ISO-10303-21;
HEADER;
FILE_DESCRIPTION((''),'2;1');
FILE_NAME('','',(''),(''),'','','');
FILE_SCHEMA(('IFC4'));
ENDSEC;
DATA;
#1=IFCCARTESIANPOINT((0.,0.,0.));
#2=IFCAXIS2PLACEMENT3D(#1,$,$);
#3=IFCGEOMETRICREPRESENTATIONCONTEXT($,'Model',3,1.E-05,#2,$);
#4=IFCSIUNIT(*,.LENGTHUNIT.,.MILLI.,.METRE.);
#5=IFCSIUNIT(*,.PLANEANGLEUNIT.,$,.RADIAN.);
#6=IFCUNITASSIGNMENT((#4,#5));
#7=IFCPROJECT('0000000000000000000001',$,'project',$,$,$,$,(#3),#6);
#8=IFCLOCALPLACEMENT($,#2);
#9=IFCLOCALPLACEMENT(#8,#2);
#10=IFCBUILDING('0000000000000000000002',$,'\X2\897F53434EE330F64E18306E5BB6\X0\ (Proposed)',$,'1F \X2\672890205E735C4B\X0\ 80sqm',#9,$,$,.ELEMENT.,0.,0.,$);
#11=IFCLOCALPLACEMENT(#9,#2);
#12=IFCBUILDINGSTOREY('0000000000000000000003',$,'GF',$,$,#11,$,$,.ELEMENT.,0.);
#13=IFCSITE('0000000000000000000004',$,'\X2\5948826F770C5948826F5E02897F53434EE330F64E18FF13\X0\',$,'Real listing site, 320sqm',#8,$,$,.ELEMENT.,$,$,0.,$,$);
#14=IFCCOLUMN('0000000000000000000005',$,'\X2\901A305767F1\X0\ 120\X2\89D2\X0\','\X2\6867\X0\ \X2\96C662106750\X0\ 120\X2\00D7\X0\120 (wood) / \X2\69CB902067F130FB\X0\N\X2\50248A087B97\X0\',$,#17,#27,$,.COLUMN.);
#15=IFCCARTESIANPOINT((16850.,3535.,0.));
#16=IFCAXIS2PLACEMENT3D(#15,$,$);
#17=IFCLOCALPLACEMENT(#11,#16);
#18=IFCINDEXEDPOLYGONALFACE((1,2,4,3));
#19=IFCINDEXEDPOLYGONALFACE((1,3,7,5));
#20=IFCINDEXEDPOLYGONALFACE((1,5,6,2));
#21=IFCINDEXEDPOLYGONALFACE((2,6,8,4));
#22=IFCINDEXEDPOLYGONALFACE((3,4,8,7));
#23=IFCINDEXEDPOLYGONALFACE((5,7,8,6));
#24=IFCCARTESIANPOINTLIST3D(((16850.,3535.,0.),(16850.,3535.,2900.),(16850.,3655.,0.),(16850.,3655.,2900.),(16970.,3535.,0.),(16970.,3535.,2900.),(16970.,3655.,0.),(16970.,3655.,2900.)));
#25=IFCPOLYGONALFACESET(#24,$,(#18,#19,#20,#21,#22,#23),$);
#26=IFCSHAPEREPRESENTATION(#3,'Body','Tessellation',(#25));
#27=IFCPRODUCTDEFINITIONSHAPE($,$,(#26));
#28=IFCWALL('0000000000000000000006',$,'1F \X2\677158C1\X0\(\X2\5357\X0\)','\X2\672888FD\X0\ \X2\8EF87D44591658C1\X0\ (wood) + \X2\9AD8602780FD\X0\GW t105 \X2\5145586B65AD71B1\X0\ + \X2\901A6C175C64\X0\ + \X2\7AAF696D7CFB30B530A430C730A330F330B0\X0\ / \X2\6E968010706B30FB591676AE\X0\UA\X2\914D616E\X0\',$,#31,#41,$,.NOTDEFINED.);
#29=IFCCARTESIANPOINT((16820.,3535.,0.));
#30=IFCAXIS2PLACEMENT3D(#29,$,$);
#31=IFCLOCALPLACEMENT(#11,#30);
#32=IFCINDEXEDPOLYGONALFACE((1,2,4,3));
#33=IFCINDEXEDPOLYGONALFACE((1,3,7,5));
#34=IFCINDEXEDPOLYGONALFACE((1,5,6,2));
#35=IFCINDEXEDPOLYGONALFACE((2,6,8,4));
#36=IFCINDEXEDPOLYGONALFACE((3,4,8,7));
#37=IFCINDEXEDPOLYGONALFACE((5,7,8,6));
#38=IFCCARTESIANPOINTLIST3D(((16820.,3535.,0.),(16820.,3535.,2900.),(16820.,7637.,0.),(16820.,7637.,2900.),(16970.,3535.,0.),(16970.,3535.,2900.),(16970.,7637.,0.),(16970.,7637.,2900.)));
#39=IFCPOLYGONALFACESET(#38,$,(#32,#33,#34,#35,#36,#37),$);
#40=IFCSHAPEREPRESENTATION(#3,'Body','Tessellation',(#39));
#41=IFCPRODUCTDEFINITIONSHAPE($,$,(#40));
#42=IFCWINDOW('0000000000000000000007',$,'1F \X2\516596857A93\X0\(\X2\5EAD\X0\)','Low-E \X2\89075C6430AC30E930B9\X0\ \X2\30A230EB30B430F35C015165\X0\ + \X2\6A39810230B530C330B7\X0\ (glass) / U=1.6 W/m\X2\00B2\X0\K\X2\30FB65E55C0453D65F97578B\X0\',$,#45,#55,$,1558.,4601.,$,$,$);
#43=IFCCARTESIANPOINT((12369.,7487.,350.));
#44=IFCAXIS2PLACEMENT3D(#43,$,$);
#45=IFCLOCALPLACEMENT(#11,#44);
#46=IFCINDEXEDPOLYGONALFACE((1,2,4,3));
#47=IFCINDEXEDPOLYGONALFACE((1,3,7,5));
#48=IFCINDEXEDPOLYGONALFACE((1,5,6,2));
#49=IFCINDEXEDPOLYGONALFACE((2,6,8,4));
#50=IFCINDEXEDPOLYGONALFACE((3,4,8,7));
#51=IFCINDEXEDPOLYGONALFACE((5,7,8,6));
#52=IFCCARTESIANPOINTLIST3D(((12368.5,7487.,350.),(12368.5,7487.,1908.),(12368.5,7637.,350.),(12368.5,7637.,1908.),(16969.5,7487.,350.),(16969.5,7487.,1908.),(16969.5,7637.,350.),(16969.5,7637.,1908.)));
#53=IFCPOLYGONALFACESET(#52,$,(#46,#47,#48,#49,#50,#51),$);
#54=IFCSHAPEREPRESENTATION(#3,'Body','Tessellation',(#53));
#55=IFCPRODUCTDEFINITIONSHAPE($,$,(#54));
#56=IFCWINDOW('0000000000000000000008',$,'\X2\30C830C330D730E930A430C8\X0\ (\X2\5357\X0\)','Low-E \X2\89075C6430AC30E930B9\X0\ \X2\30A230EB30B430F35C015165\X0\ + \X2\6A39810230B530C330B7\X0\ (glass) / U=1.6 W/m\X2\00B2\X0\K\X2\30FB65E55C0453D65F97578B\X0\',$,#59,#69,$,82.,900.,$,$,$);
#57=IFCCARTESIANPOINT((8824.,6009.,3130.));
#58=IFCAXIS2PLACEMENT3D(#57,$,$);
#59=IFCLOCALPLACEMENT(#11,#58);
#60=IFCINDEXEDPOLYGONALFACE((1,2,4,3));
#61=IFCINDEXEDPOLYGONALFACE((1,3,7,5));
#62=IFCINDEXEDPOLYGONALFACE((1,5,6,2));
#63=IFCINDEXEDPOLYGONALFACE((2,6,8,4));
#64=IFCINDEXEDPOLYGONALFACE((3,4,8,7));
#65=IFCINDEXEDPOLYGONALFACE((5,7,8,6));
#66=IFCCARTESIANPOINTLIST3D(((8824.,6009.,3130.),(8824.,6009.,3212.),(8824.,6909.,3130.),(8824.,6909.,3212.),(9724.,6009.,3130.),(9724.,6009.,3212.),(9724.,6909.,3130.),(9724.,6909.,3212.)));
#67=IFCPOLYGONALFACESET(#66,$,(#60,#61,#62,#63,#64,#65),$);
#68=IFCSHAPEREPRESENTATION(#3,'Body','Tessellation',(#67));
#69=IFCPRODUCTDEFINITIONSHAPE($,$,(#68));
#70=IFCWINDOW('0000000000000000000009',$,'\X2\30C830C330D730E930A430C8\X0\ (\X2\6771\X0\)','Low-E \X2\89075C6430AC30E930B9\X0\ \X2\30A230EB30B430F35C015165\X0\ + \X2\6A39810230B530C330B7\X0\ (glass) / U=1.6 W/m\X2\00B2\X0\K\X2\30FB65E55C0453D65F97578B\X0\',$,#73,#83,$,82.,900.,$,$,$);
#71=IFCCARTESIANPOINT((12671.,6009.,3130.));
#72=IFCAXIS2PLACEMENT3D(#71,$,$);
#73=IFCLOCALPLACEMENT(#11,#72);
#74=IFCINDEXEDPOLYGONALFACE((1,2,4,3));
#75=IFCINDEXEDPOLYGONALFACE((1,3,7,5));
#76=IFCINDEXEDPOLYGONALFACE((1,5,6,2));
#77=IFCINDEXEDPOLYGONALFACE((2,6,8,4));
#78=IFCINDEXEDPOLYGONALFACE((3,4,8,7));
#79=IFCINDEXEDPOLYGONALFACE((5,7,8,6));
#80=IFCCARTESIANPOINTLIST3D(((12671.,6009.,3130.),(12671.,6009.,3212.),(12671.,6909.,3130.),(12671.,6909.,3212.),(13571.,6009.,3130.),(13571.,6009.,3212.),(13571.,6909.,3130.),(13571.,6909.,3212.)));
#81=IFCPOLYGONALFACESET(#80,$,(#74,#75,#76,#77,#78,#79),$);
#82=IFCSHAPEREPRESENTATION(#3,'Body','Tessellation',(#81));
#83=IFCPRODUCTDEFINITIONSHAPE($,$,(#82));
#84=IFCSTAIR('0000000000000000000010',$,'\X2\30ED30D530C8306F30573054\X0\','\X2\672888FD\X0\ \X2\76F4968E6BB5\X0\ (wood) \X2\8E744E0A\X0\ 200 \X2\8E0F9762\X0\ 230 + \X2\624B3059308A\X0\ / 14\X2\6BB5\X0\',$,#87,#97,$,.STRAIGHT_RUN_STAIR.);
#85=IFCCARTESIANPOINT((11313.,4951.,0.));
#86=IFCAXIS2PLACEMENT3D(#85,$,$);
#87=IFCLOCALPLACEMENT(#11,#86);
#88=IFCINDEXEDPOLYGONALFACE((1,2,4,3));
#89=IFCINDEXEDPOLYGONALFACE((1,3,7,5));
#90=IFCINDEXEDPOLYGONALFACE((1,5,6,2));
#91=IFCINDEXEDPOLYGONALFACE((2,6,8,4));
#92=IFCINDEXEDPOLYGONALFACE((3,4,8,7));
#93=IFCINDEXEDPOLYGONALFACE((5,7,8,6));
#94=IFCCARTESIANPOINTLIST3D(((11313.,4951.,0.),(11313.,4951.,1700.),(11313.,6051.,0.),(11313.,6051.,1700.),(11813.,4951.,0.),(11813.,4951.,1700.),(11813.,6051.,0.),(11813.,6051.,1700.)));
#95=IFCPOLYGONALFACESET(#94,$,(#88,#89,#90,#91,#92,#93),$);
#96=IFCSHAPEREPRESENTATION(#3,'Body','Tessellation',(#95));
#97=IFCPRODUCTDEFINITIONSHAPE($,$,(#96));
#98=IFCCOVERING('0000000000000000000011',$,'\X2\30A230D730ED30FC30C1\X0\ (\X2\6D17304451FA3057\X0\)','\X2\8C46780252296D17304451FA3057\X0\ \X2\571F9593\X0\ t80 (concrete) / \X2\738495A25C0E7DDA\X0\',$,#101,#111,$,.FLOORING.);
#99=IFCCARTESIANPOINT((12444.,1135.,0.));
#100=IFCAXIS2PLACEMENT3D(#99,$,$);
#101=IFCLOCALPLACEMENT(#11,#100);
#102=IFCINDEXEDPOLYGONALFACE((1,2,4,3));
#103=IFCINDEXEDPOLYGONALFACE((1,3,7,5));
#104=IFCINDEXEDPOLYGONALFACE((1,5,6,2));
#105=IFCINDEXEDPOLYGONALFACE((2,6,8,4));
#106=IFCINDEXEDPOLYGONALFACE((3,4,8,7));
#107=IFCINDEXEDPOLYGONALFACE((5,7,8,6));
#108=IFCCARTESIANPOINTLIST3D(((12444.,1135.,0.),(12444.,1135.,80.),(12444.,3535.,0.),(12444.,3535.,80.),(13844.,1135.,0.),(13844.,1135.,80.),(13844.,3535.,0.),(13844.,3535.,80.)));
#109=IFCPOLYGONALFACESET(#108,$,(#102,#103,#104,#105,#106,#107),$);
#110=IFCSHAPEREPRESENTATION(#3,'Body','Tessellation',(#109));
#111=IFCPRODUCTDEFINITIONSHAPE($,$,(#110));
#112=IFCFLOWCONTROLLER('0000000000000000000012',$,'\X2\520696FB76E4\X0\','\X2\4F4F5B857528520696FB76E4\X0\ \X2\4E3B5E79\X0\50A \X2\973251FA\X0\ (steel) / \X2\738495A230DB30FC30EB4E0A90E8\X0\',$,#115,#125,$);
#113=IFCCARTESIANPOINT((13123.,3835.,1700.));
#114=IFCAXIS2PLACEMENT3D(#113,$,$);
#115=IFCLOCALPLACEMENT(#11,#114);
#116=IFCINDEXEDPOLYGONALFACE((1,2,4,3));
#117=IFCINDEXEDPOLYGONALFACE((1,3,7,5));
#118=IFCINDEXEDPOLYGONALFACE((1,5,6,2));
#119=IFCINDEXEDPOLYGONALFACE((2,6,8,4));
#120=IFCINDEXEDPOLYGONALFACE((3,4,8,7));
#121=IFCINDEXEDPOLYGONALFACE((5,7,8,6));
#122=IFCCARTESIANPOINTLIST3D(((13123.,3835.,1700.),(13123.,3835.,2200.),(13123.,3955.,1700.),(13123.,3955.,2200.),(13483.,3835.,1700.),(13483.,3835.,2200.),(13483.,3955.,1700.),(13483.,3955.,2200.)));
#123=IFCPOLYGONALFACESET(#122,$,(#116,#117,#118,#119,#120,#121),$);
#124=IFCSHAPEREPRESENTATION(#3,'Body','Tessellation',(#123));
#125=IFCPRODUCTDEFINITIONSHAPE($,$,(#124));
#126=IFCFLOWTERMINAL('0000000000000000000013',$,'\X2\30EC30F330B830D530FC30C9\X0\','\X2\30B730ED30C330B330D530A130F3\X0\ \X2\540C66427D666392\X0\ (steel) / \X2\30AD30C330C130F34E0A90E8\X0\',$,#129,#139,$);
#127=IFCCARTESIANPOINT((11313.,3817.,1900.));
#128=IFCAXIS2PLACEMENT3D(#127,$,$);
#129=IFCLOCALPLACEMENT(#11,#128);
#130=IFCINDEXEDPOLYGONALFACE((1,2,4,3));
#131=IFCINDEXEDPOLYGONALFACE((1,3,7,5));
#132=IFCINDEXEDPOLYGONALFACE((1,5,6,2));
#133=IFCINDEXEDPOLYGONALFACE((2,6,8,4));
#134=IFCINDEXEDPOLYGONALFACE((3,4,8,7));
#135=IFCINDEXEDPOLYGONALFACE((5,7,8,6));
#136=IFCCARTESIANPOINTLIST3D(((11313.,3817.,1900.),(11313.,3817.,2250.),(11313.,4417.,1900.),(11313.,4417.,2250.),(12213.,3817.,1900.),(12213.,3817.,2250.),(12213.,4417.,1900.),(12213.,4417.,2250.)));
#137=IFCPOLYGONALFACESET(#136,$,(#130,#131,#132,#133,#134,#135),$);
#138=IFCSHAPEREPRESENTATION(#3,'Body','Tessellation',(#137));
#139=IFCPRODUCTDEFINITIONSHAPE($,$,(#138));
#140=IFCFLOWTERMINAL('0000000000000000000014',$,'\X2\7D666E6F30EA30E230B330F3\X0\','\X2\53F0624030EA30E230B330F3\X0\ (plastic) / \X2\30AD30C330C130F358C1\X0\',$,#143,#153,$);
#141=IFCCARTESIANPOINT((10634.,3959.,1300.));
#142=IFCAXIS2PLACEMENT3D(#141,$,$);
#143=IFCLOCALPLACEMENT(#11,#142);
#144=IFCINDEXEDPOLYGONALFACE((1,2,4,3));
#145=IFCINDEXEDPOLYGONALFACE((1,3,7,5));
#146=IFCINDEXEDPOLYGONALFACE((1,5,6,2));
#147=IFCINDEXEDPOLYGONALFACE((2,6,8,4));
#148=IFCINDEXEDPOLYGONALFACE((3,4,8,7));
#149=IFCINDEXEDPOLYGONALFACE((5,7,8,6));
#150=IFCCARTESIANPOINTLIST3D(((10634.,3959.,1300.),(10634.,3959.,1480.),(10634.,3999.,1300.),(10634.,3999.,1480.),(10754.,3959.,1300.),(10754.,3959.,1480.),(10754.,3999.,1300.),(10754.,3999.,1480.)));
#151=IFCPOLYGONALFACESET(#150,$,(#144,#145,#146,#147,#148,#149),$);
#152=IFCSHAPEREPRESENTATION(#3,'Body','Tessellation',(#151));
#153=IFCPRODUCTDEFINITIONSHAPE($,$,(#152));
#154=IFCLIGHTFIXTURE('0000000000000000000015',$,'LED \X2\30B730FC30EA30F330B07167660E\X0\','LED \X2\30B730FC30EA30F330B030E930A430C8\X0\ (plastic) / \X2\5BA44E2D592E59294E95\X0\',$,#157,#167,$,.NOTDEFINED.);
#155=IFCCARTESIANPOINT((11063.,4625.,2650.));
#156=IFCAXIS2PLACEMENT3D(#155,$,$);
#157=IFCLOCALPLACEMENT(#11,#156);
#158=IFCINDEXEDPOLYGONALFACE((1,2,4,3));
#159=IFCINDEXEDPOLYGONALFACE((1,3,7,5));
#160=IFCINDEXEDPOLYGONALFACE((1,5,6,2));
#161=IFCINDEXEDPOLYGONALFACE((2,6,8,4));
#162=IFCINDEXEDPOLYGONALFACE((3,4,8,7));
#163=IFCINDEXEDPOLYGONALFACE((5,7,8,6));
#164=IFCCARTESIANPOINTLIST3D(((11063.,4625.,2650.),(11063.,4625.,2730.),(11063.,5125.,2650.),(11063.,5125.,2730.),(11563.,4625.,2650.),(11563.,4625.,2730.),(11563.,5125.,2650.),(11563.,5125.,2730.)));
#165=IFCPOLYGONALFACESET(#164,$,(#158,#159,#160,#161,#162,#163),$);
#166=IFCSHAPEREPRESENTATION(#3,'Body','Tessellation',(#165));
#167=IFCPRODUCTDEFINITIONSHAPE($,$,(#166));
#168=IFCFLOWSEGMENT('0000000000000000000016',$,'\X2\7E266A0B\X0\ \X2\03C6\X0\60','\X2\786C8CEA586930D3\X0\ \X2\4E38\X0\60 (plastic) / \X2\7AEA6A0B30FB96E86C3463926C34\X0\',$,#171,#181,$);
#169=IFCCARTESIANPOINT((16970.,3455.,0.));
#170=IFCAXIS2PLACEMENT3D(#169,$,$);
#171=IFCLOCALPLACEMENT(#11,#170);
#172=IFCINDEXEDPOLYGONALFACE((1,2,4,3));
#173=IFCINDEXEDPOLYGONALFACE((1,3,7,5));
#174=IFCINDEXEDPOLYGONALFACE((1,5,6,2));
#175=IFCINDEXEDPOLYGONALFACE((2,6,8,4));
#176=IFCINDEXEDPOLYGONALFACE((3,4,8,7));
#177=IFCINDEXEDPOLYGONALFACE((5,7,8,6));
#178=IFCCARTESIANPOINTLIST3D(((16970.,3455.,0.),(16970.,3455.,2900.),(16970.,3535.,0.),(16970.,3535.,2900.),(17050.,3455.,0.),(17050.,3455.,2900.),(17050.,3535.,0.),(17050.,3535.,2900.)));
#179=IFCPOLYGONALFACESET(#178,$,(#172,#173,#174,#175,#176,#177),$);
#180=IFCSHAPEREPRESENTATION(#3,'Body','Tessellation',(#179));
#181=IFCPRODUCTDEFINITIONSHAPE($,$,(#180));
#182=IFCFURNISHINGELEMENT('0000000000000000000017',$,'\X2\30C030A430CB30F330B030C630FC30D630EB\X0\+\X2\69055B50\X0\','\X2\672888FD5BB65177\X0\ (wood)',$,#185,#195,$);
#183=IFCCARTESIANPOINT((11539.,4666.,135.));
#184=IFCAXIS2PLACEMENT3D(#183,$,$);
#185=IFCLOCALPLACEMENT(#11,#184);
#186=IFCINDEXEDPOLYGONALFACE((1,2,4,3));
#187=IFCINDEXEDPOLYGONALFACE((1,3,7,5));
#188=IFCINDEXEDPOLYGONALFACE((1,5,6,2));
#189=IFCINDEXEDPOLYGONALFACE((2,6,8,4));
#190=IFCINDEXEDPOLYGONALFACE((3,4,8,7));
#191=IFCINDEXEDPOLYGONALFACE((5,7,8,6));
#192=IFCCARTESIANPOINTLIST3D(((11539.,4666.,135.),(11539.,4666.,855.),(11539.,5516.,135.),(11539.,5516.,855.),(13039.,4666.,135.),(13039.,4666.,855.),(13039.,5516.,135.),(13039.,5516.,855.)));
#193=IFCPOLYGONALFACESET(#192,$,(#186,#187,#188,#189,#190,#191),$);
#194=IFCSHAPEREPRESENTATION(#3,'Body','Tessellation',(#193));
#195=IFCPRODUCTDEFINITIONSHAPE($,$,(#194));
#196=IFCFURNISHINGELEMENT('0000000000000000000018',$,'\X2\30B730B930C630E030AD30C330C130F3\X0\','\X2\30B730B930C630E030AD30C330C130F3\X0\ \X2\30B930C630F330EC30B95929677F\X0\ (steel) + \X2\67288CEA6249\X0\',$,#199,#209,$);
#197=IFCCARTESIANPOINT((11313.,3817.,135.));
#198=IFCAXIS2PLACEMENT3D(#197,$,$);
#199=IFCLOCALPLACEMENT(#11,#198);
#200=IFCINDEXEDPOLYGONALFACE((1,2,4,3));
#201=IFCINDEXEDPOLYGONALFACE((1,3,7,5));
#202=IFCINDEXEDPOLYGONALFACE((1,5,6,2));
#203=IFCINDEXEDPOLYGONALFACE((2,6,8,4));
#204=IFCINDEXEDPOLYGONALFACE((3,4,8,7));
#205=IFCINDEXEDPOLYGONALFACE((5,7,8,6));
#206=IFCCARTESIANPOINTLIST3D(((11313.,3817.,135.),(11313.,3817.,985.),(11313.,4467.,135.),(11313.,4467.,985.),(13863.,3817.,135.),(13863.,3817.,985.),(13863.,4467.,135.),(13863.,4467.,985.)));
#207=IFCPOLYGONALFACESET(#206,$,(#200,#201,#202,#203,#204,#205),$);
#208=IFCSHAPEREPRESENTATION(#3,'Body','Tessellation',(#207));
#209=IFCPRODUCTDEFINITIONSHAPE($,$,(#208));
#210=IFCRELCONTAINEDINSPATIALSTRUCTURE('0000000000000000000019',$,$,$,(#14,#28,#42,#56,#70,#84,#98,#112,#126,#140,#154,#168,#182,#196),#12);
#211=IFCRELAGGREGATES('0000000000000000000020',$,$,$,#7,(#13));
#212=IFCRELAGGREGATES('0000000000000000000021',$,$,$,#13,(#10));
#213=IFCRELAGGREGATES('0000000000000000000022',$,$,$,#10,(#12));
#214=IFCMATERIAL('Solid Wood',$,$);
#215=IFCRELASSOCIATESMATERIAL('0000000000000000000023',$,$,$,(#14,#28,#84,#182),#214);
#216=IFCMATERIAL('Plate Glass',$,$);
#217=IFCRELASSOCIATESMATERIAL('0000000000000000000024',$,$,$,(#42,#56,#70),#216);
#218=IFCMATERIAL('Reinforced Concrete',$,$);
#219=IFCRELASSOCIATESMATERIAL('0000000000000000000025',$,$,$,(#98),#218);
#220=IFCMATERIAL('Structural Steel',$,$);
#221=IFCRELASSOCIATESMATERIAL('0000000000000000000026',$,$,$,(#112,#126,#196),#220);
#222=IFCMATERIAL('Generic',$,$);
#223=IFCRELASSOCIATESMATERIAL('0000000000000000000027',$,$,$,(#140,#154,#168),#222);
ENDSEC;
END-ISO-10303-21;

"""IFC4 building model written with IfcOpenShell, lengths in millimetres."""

from ifc_helpers import new_model, si_unit, frame, frame_2d, origin, place, context, project, spatial, rectangle, extrude, material, element, fill, save


model = new_model("IFC4")

# Units and contexts
model_context = context("Model", 3, precision=1e-05, world=origin())
ifc_project = project(units=[si_unit("LENGTHUNIT", "METRE", prefix="MILLI"), si_unit("PLANEANGLEUNIT", "RADIAN")], contexts=[model_context])

# Site, building, storey
site_placement = place(None, origin())
site = spatial("IfcSite", under=ifc_project, at=site_placement, Name="奈良県奈良市西千代ヶ丘３", ObjectType="Real listing site, 320sqm", CompositionType="ELEMENT", RefElevation=0.0)
building_placement = place(site_placement, origin())
building = spatial("IfcBuilding", under=site, at=building_placement, Name="西千代ヶ丘の家 (Proposed)", ObjectType="1F 木造平屋 80sqm", CompositionType="ELEMENT", ElevationOfRefHeight=0.0, ElevationOfTerrain=0.0)
storey_placement = place(building_placement, origin())
storey = spatial("IfcBuildingStorey", under=building, at=storey_placement, Name="GF", CompositionType="ELEMENT", Elevation=0.0)

# Column
ifc_material_1 = material(Name="Solid Wood")
column_1_placement = place(storey_placement, frame((16850.0, 3535.0, 0.0)))
element("IfcColumn", 1, at=column_1_placement, inside=storey, material=ifc_material_1, Name="通し柱 120角", Description="桧 集成材 120×120 (wood) / 構造柱・N値計算", PredefinedType="COLUMN", context=model_context, shape_type="SweptSolid", body=[
    extrude(rectangle(XDim=120.0, YDim=120.0, at=frame_2d((60.0, 60.0))), frame((16850.0, 3535.0, 0.0)), (0.0, 0.0, 1.0), 2900.0),
])

# Wall, opening, window
wall_1_placement = place(storey_placement, frame((16820.0, 3535.0, 0.0)))
wall_1 = element("IfcWall", 2, at=wall_1_placement, inside=storey, material=ifc_material_1, Name="1F 東壁(南)", Description="木製 軸組外壁 (wood) + 高性能GW t105 充填断熱 + 通気層 + 窯業系サイディング / 準耐火・外皮UA配慮", PredefinedType="NOTDEFINED", context=model_context, shape_type="SweptSolid", body=[
    extrude(rectangle(XDim=150.0, YDim=4102.0, at=frame_2d((75.0, 2051.0))), frame((16820.0, 3535.0, 0.0)), (0.0, 0.0, 1.0), 2900.0),
])
opening_1_placement = place(storey_placement, frame((12369.0, 7487.0, 350.0)))
opening_1 = element("IfcOpeningElement", 3, at=opening_1_placement, cuts=wall_1, PredefinedType="NOTDEFINED", context=model_context, shape_type="SweptSolid", body=[
    extrude(rectangle(XDim=4601.0, YDim=150.0, at=frame_2d((2300.0, 75.0))), frame((12369.0, 7487.0, 350.0)), (0.0, 0.0, 1.0), 1558.0),
])
ifc_material_2 = material(Name="Plate Glass")
window_1_placement = place(storey_placement, frame((12369.0, 7487.0, 350.0)))
window_1 = element("IfcWindow", 4, at=window_1_placement, inside=storey, material=ifc_material_2, Name="1F 入隅窓(庭)", Description="Low-E 複層ガラス アルゴン封入 + 樹脂サッシ (glass) / U=1.6 W/m²K・日射取得型", OverallHeight=1558.0, OverallWidth=4601.0, context=model_context, shape_type="SweptSolid", body=[
    extrude(rectangle(XDim=4601.0, YDim=150.0, at=frame_2d((2300.0, 75.0))), frame((12369.0, 7487.0, 350.0)), (0.0, 0.0, 1.0), 1558.0),
])
fill(opening_1, window_1)

# Windows
window_2_placement = place(storey_placement, frame((8824.0, 6009.0, 3130.0)))
element("IfcWindow", 5, at=window_2_placement, inside=storey, material=ifc_material_2, Name="トップライト (南)", Description="Low-E 複層ガラス アルゴン封入 + 樹脂サッシ (glass) / U=1.6 W/m²K・日射取得型", OverallHeight=82.0, OverallWidth=900.0, context=model_context, shape_type="SweptSolid", body=[
    extrude(rectangle(XDim=900.0, YDim=900.0, at=frame_2d((450.0, 450.0))), frame((8824.0, 6009.0, 3130.0)), (0.0, 0.0, 1.0), 82.0),
])
window_3_placement = place(storey_placement, frame((12671.0, 6009.0, 3130.0)))
element("IfcWindow", 6, at=window_3_placement, inside=storey, material=ifc_material_2, Name="トップライト (東)", Description="Low-E 複層ガラス アルゴン封入 + 樹脂サッシ (glass) / U=1.6 W/m²K・日射取得型", OverallHeight=82.0, OverallWidth=900.0, context=model_context, shape_type="SweptSolid", body=[
    extrude(rectangle(XDim=900.0, YDim=900.0, at=frame_2d((450.0, 450.0))), frame((12671.0, 6009.0, 3130.0)), (0.0, 0.0, 1.0), 82.0),
])

# Stair
stair_placement = place(storey_placement, frame((11313.0, 4951.0, 0.0)))
element("IfcStair", 7, at=stair_placement, inside=storey, material=ifc_material_1, Name="ロフトはしご", Description="木製 直階段 (wood) 蹴上 200 踏面 230 + 手すり / 14段", PredefinedType="STRAIGHT_RUN_STAIR", context=model_context, shape_type="SweptSolid", body=[
    extrude(rectangle(XDim=500.0, YDim=1100.0, at=frame_2d((250.0, 550.0))), frame((11313.0, 4951.0, 0.0)), (0.0, 0.0, 1.0), 1700.0),
])

# Covering
ifc_material_3 = material(Name="Reinforced Concrete")
covering_placement = place(storey_placement, frame((12444.0, 1135.0, 0.0)))
element("IfcCovering", 8, at=covering_placement, inside=storey, material=ifc_material_3, Name="アプローチ (洗い出し)", Description="豆砂利洗い出し 土間 t80 (concrete) / 玄関導線", PredefinedType="FLOORING", context=model_context, shape_type="SweptSolid", body=[
    extrude(rectangle(XDim=1400.0, YDim=2400.0, at=frame_2d((700.0, 1200.0))), frame((12444.0, 1135.0, 0.0)), (0.0, 0.0, 1.0), 80.0),
])

# Flow controller
ifc_material_4 = material(Name="Structural Steel")
flow_controller_placement = place(storey_placement, frame((13123.0, 3835.0, 1700.0)))
element("IfcFlowController", 9, at=flow_controller_placement, inside=storey, material=ifc_material_4, Name="分電盤", Description="住宅用分電盤 主幹50A 露出 (steel) / 玄関ホール上部", context=model_context, shape_type="SweptSolid", body=[
    extrude(rectangle(XDim=360.0, YDim=120.0, at=frame_2d((180.0, 60.0))), frame((13123.0, 3835.0, 1700.0)), (0.0, 0.0, 1.0), 500.0),
])

# Flow terminals
flow_terminal_1_placement = place(storey_placement, frame((11313.0, 3817.0, 1900.0)))
element("IfcFlowTerminal", 10, at=flow_terminal_1_placement, inside=storey, material=ifc_material_4, Name="レンジフード", Description="シロッコファン 同時給排 (steel) / キッチン上部", context=model_context, shape_type="SweptSolid", body=[
    extrude(rectangle(XDim=900.0, YDim=600.0, at=frame_2d((450.0, 300.0))), frame((11313.0, 3817.0, 1900.0)), (0.0, 0.0, 1.0), 350.0),
])
ifc_material_5 = material(Name="Generic")
flow_terminal_2_placement = place(storey_placement, frame((10634.0, 3959.0, 1300.0)))
element("IfcFlowTerminal", 11, at=flow_terminal_2_placement, inside=storey, material=ifc_material_5, Name="給湯リモコン", Description="台所リモコン (plastic) / キッチン壁", context=model_context, shape_type="SweptSolid", body=[
    extrude(rectangle(XDim=120.0, YDim=40.0, at=frame_2d((60.0, 20.0))), frame((10634.0, 3959.0, 1300.0)), (0.0, 0.0, 1.0), 180.0),
])

# Light fixture
light_fixture_placement = place(storey_placement, frame((11063.0, 4625.0, 2650.0)))
element("IfcLightFixture", 12, at=light_fixture_placement, inside=storey, material=ifc_material_5, Name="LED シーリング照明", Description="LED シーリングライト (plastic) / 室中央天井", PredefinedType="NOTDEFINED", context=model_context, shape_type="SweptSolid", body=[
    extrude(rectangle(XDim=500.0, YDim=500.0, at=frame_2d((250.0, 250.0))), frame((11063.0, 4625.0, 2650.0)), (0.0, 0.0, 1.0), 80.0),
])

# Flow segment
flow_segment_placement = place(storey_placement, frame((16970.0, 3455.0, 0.0)))
element("IfcFlowSegment", 13, at=flow_segment_placement, inside=storey, material=ifc_material_5, Name="縦樋 φ60", Description="硬質塩ビ 丸60 (plastic) / 竪樋・雨水排水", context=model_context, shape_type="SweptSolid", body=[
    extrude(rectangle(XDim=80.0, YDim=80.0, at=frame_2d((40.0, 40.0))), frame((16970.0, 3455.0, 0.0)), (0.0, 0.0, 1.0), 2900.0),
])

# Furnishing elements
furnishing_1_placement = place(storey_placement, frame((11539.0, 4666.0, 135.0)))
element("IfcFurnishingElement", 14, at=furnishing_1_placement, inside=storey, material=ifc_material_1, Name="ダイニングテーブル+椅子", Description="木製家具 (wood)", context=model_context, shape_type="SweptSolid", body=[
    extrude(rectangle(XDim=1500.0, YDim=850.0, at=frame_2d((750.0, 425.0))), frame((11539.0, 4666.0, 135.0)), (0.0, 0.0, 1.0), 720.0),
])
furnishing_2_placement = place(storey_placement, frame((11313.0, 3817.0, 135.0)))
element("IfcFurnishingElement", 15, at=furnishing_2_placement, inside=storey, material=ifc_material_4, Name="システムキッチン", Description="システムキッチン ステンレス天板 (steel) + 木質扉", context=model_context, shape_type="SweptSolid", body=[
    extrude(rectangle(XDim=2550.0, YDim=650.0, at=frame_2d((1275.0, 325.0))), frame((11313.0, 3817.0, 135.0)), (0.0, 0.0, 1.0), 850.0),
])

save(model, "model.ifc")
